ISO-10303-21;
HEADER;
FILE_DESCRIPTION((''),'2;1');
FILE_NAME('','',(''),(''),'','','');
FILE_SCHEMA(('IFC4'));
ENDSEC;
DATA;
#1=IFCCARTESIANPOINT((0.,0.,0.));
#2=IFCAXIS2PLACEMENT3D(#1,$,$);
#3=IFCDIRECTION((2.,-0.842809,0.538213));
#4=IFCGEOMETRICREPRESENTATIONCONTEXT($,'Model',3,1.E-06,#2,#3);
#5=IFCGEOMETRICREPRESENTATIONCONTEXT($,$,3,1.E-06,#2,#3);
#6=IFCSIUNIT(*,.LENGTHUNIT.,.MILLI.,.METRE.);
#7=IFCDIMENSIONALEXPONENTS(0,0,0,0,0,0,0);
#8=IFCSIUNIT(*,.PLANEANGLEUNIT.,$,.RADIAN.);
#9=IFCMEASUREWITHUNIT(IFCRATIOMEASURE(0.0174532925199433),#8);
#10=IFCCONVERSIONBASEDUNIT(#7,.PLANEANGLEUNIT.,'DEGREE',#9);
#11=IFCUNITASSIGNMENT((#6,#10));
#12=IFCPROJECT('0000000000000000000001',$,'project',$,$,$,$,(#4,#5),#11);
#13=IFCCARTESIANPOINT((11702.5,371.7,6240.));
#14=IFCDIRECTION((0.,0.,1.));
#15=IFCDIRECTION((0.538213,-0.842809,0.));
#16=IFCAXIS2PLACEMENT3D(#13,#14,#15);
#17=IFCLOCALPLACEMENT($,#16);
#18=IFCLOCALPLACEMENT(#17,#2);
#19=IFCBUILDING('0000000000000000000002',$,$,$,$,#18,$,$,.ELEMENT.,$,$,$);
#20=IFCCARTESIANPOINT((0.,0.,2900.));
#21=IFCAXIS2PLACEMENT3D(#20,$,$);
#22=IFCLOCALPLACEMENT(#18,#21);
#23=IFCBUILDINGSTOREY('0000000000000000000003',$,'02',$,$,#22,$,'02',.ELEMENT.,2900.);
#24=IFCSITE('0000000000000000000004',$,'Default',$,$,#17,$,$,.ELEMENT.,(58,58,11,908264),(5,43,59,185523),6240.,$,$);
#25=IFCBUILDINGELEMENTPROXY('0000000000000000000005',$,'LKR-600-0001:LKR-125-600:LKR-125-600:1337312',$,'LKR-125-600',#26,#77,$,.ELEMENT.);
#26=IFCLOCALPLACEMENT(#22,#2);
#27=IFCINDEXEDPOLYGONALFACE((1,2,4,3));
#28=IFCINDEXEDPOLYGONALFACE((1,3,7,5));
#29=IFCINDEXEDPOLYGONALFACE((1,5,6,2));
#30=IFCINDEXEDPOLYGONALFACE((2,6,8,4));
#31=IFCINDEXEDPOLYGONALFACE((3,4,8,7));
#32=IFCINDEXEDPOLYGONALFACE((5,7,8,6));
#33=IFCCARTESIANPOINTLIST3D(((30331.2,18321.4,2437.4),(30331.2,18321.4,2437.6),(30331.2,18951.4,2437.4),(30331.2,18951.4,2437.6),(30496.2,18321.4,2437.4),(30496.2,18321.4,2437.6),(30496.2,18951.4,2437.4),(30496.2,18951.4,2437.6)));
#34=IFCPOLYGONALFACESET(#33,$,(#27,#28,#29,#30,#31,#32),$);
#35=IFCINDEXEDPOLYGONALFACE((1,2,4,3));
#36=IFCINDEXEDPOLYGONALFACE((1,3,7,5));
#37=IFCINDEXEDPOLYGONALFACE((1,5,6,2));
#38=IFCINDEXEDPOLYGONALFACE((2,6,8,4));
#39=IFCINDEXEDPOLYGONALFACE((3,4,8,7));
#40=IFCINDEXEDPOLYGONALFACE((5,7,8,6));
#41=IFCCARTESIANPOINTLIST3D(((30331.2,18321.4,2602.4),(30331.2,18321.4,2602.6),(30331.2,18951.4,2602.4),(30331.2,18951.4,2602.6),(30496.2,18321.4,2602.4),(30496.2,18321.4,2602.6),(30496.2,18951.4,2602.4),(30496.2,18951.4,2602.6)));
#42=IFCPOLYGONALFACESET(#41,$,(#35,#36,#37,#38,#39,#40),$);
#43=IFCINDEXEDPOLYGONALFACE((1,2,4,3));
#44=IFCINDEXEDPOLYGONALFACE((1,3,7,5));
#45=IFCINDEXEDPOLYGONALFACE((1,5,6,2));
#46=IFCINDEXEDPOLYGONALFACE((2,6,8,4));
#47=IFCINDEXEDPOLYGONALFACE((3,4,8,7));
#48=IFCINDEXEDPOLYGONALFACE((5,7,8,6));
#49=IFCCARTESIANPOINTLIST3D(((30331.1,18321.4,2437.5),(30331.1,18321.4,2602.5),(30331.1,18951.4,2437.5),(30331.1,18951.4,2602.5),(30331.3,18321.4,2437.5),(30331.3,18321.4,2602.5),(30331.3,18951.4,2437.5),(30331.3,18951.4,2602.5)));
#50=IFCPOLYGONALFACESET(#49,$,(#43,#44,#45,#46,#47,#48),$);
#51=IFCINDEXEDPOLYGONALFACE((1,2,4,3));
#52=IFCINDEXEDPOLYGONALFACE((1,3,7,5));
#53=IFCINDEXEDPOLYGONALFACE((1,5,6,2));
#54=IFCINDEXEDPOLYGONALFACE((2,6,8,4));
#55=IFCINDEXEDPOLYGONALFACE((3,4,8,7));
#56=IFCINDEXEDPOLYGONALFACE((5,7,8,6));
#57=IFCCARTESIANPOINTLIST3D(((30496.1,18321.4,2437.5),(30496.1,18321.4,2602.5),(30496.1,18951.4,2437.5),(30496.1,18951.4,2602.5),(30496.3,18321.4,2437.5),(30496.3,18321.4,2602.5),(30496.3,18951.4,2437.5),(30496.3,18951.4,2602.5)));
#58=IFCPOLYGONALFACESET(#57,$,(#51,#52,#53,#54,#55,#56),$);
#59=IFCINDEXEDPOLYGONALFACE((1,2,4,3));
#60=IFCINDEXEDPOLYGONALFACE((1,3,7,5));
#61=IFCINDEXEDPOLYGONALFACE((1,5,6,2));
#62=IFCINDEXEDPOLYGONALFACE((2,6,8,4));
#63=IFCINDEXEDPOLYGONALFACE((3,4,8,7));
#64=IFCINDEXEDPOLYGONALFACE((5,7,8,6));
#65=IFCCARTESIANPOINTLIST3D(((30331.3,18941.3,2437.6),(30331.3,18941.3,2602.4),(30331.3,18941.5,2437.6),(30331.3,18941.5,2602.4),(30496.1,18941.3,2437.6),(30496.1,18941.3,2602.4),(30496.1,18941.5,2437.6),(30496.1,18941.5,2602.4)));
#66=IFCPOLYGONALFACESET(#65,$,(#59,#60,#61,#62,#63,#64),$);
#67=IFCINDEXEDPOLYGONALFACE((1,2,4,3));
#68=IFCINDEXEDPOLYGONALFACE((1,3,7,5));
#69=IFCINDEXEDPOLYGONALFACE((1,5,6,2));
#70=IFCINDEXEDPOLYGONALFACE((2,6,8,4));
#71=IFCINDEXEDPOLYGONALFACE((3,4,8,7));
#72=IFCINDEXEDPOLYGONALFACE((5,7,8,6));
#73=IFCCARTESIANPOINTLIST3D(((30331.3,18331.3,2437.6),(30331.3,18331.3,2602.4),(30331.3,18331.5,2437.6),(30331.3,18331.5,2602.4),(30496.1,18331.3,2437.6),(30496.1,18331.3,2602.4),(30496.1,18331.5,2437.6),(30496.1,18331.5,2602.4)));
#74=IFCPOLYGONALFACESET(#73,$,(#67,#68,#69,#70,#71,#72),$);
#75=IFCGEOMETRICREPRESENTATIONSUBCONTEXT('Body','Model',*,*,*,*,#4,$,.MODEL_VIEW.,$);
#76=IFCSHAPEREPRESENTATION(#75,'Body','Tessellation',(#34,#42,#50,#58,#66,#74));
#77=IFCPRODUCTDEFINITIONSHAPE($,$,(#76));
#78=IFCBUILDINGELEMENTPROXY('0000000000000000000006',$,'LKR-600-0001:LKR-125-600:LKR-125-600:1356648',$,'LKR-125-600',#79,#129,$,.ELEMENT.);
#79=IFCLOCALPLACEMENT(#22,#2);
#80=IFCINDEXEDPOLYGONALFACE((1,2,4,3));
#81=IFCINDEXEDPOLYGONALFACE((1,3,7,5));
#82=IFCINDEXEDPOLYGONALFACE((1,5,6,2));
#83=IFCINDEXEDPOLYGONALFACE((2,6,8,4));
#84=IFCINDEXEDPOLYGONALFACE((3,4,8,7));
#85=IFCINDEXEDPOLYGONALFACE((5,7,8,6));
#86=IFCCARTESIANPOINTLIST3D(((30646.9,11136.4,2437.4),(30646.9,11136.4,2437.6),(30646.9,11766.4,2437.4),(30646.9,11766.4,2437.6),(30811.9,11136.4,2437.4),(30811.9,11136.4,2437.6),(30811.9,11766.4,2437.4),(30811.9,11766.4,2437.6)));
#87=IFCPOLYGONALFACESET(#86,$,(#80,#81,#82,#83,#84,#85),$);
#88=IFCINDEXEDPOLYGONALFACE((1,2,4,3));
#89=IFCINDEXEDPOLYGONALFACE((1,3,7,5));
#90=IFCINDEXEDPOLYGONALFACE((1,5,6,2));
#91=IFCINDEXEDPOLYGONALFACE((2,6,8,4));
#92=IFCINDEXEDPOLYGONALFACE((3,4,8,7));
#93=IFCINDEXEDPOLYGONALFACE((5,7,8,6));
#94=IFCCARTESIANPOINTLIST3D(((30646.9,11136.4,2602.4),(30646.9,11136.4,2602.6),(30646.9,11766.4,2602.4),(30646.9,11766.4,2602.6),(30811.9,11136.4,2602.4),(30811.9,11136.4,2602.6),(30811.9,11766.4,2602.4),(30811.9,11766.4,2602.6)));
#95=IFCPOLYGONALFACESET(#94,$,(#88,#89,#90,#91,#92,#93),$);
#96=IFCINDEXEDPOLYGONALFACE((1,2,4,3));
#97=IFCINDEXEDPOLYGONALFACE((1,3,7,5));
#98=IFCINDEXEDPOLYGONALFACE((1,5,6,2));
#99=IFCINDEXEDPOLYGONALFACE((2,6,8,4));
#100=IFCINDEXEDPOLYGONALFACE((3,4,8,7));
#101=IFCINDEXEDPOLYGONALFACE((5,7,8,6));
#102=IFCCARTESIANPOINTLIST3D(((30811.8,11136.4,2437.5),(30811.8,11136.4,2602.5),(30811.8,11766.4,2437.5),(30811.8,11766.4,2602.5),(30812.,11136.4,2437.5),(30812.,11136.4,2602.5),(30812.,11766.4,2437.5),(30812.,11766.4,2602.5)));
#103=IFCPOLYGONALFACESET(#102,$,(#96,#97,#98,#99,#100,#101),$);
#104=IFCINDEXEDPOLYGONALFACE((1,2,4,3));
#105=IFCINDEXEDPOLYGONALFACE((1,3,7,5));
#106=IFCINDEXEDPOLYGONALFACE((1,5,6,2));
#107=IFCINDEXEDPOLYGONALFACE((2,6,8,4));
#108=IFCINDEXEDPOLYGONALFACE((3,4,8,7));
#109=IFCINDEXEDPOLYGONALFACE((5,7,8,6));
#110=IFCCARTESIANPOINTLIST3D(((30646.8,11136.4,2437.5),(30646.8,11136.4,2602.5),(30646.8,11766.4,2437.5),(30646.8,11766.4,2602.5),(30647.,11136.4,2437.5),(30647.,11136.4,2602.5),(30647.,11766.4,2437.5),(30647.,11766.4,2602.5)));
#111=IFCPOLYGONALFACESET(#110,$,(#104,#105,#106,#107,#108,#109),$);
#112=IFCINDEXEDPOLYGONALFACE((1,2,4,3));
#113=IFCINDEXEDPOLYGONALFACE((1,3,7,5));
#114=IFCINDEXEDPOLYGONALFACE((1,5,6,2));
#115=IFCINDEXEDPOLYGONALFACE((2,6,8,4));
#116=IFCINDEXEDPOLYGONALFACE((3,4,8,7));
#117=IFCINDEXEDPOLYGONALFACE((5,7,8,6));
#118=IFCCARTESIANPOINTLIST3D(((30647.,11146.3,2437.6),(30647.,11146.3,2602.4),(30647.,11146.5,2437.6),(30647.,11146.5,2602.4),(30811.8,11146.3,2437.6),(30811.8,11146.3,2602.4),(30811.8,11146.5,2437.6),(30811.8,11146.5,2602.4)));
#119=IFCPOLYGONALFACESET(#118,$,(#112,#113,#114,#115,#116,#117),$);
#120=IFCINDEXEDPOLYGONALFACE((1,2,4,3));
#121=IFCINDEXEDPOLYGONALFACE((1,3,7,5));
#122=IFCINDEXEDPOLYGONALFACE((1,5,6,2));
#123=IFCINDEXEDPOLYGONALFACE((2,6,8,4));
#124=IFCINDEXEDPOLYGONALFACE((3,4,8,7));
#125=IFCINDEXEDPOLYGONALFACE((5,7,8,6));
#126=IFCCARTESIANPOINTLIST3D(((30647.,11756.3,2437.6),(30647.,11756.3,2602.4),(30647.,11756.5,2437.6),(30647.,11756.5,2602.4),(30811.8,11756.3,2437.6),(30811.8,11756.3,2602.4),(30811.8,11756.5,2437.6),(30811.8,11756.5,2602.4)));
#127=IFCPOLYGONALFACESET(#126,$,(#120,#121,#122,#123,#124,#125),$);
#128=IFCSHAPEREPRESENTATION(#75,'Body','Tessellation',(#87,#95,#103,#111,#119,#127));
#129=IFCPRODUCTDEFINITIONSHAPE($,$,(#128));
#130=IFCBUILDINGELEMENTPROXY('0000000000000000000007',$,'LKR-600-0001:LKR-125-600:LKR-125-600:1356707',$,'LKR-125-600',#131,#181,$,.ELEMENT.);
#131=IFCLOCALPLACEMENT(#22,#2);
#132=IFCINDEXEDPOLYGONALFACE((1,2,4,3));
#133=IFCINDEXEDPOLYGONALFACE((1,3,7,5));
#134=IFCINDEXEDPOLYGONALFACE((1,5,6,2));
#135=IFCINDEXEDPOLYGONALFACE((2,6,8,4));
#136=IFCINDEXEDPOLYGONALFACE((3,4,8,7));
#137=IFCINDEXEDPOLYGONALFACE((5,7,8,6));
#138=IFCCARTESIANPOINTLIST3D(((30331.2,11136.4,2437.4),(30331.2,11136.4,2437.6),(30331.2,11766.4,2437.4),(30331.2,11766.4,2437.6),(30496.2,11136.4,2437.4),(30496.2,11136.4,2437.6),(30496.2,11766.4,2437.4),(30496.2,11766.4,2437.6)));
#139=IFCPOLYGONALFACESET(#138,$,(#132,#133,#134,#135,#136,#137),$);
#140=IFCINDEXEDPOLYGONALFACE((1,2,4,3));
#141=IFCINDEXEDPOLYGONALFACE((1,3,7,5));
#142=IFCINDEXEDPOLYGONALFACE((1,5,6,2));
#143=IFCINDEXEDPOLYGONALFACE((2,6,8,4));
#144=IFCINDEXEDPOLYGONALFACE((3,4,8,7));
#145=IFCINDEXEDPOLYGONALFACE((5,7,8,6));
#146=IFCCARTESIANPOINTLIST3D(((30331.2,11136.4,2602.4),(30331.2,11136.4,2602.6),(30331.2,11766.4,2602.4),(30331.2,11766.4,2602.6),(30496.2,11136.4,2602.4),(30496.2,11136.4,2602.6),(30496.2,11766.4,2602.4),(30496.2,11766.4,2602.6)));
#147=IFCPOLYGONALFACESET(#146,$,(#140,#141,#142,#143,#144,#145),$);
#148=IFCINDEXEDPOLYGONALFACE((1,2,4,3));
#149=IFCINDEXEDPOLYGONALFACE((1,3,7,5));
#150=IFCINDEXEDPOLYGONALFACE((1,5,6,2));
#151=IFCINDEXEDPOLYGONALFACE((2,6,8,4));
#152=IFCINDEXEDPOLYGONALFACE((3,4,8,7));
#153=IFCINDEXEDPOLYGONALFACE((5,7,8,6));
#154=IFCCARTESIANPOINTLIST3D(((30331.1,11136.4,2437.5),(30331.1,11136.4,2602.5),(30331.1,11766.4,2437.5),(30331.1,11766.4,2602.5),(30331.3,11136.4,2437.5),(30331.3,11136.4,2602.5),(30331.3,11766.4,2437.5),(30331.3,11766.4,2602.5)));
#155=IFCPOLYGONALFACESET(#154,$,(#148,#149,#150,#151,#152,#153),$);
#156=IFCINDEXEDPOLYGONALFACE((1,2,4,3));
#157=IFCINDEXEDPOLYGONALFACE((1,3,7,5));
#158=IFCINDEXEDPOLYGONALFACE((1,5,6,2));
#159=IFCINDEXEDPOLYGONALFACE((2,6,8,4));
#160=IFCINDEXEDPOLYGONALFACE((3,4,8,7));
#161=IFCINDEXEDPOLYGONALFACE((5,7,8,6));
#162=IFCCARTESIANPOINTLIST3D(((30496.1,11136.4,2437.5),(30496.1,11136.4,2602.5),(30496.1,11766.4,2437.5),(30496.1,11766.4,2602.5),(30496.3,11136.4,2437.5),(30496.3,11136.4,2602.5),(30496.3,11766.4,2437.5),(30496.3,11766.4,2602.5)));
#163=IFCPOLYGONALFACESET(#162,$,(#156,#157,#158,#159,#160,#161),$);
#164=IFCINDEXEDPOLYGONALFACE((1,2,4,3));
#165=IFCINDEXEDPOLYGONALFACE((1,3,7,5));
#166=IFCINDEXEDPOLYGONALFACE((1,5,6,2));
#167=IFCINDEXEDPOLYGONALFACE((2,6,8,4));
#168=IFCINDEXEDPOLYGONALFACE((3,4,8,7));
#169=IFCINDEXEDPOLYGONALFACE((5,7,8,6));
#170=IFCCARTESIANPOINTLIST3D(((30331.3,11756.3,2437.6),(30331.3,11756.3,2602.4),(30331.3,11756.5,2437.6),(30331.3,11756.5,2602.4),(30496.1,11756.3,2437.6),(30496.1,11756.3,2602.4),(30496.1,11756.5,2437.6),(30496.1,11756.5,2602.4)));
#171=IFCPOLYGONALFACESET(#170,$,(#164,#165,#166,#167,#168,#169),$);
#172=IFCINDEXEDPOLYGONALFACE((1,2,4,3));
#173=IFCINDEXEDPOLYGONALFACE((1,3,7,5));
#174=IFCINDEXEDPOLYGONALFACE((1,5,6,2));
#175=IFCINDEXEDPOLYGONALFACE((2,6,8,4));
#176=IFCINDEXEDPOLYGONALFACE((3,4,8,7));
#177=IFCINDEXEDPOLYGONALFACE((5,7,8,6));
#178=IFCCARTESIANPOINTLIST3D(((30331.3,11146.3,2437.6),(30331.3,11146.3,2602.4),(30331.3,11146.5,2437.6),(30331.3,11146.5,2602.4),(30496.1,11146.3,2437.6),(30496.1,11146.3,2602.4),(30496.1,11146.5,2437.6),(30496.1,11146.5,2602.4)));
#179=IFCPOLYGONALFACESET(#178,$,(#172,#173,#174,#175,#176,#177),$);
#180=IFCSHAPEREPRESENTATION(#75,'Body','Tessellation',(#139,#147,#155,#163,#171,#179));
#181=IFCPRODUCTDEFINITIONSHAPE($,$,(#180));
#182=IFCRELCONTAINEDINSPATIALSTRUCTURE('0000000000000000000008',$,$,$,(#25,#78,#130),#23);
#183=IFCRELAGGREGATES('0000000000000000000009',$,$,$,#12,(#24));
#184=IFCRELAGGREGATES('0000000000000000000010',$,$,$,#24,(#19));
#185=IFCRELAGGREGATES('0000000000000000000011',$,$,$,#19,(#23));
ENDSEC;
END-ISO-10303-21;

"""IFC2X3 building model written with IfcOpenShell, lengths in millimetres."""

from ifc_helpers import new_model, entity, si_unit, converted_unit, direction, frame, frame_2d, origin, place, context, subcontext, project, spatial, rectangle, extrude, source, transform, mapped, element, save


model = new_model("IFC2X3")

# Units and contexts
model_context = context("Model", 3, precision=1e-06, world=origin(), true_north=direction((2.0, -0.842809, 0.538213)))
context_of_model = context(None, 3, precision=1e-06, world=origin(), true_north=direction((2.0, -0.842809, 0.538213)))
body_context = subcontext(model_context, "Body", "Model", "MODEL_VIEW")
ifc_project = project(units=[si_unit("LENGTHUNIT", "METRE", prefix="MILLI"), converted_unit("PLANEANGLEUNIT", "DEGREE", entity("IfcRatioMeasure", 0.0174532925199433), si_unit("PLANEANGLEUNIT", "RADIAN"), dimensions=[0, 0, 0, 0, 0, 0, 0])], contexts=[model_context, context_of_model])

# Site, building, storey
site_placement = place(None, frame((11702.5, 371.7, 6240.0), z_axis=(0.0, 0.0, 1.0), x_axis=(0.538213, -0.842809, 0.0)))
site = spatial("IfcSite", under=ifc_project, at=site_placement, Name="Default", CompositionType="ELEMENT", RefLatitude=(58, 58, 11, 908264), RefLongitude=(5, 43, 59, 185523), RefElevation=6240.0)
building_placement = place(site_placement, origin())
building = spatial("IfcBuilding", under=site, at=building_placement, CompositionType="ELEMENT")
storey_placement = place(building_placement, frame((0.0, 0.0, 2900.0)))
storey = spatial("IfcBuildingStorey", under=building, at=storey_placement, Name="02", LongName="02", CompositionType="ELEMENT", Elevation=2900.0)

# Building element proxies
shared_shape_1 = source(origin(), body_context, "Body", "SweptSolid", [
    extrude(rectangle(XDim=165.0, YDim=630.0, at=frame_2d((0.0, 0.0), x_axis=(1.0, 0.0))), frame((0.0, 0.0, -82.6), z_axis=(0.0, 0.0, 1.0), x_axis=(0.0, -1.0, 0.0)), (0.0, 0.0, 1.0), 0.2),
    extrude(rectangle(XDim=165.0, YDim=630.0, at=frame_2d((0.0, 0.0), x_axis=(1.0, 0.0))), frame((0.0, 0.0, 82.4), z_axis=(0.0, 0.0, 1.0), x_axis=(0.0, -1.0, 0.0)), (0.0, 0.0, 1.0), 0.2),
    extrude(rectangle(XDim=0.2, YDim=630.0, at=frame_2d((0.0, 0.0), x_axis=(1.0, 0.0))), frame((0.0, 82.5, -82.5), z_axis=(0.0, 0.0, 1.0), x_axis=(0.0, 1.0, 0.0)), (0.0, 0.0, 1.0), 165.0),
    extrude(rectangle(XDim=0.2, YDim=630.0, at=frame_2d((0.0, 0.0), x_axis=(1.0, 0.0))), frame((0.0, -82.5, -82.5), z_axis=(0.0, 0.0, 1.0), x_axis=(0.0, 1.0, 0.0)), (0.0, 0.0, 1.0), 165.0),
    extrude(rectangle(XDim=0.2, YDim=164.8, at=frame_2d((0.0, 0.0), x_axis=(1.0, 0.0))), frame((305.0, 0.0, -82.4)), (0.0, 0.0, 1.0), 164.8),
    extrude(rectangle(XDim=0.2, YDim=164.8, at=frame_2d((0.0, 0.0), x_axis=(1.0, 0.0))), frame((-305.0, 0.0, -82.4)), (0.0, 0.0, 1.0), 164.8),
])
for number, where, z_axis, x_axis, name in (
    (1, (30413.7, 18636.4, 2520.0), (0.0, 0.0, 1.0), (0.0, 1.0, 0.0), "LKR-600-0001:LKR-125-600:LKR-125-600:1337312"),
    (2, (30729.4, 11451.4, 2520.0), (0.0, 0.0, 1.0), (0.0, -1.0, 0.0), "LKR-600-0001:LKR-125-600:LKR-125-600:1356648"),
    (3, (30413.7, 11451.4, 2520.0), (0.0, 0.0, 1.0), (0.0, 1.0, 0.0), "LKR-600-0001:LKR-125-600:LKR-125-600:1356707"),
):
    element("IfcBuildingElementProxy", number, at=place(storey_placement, frame(where, z_axis=z_axis, x_axis=x_axis)), inside=storey, Name=name, ObjectType="LKR-125-600", CompositionType="ELEMENT", context=body_context, shape_type="MappedRepresentation", body=[
        mapped(shared_shape_1, transform((0.0, 0.0, 0.0), scale=1.0)),
    ])

save(model, "model.ifc")
